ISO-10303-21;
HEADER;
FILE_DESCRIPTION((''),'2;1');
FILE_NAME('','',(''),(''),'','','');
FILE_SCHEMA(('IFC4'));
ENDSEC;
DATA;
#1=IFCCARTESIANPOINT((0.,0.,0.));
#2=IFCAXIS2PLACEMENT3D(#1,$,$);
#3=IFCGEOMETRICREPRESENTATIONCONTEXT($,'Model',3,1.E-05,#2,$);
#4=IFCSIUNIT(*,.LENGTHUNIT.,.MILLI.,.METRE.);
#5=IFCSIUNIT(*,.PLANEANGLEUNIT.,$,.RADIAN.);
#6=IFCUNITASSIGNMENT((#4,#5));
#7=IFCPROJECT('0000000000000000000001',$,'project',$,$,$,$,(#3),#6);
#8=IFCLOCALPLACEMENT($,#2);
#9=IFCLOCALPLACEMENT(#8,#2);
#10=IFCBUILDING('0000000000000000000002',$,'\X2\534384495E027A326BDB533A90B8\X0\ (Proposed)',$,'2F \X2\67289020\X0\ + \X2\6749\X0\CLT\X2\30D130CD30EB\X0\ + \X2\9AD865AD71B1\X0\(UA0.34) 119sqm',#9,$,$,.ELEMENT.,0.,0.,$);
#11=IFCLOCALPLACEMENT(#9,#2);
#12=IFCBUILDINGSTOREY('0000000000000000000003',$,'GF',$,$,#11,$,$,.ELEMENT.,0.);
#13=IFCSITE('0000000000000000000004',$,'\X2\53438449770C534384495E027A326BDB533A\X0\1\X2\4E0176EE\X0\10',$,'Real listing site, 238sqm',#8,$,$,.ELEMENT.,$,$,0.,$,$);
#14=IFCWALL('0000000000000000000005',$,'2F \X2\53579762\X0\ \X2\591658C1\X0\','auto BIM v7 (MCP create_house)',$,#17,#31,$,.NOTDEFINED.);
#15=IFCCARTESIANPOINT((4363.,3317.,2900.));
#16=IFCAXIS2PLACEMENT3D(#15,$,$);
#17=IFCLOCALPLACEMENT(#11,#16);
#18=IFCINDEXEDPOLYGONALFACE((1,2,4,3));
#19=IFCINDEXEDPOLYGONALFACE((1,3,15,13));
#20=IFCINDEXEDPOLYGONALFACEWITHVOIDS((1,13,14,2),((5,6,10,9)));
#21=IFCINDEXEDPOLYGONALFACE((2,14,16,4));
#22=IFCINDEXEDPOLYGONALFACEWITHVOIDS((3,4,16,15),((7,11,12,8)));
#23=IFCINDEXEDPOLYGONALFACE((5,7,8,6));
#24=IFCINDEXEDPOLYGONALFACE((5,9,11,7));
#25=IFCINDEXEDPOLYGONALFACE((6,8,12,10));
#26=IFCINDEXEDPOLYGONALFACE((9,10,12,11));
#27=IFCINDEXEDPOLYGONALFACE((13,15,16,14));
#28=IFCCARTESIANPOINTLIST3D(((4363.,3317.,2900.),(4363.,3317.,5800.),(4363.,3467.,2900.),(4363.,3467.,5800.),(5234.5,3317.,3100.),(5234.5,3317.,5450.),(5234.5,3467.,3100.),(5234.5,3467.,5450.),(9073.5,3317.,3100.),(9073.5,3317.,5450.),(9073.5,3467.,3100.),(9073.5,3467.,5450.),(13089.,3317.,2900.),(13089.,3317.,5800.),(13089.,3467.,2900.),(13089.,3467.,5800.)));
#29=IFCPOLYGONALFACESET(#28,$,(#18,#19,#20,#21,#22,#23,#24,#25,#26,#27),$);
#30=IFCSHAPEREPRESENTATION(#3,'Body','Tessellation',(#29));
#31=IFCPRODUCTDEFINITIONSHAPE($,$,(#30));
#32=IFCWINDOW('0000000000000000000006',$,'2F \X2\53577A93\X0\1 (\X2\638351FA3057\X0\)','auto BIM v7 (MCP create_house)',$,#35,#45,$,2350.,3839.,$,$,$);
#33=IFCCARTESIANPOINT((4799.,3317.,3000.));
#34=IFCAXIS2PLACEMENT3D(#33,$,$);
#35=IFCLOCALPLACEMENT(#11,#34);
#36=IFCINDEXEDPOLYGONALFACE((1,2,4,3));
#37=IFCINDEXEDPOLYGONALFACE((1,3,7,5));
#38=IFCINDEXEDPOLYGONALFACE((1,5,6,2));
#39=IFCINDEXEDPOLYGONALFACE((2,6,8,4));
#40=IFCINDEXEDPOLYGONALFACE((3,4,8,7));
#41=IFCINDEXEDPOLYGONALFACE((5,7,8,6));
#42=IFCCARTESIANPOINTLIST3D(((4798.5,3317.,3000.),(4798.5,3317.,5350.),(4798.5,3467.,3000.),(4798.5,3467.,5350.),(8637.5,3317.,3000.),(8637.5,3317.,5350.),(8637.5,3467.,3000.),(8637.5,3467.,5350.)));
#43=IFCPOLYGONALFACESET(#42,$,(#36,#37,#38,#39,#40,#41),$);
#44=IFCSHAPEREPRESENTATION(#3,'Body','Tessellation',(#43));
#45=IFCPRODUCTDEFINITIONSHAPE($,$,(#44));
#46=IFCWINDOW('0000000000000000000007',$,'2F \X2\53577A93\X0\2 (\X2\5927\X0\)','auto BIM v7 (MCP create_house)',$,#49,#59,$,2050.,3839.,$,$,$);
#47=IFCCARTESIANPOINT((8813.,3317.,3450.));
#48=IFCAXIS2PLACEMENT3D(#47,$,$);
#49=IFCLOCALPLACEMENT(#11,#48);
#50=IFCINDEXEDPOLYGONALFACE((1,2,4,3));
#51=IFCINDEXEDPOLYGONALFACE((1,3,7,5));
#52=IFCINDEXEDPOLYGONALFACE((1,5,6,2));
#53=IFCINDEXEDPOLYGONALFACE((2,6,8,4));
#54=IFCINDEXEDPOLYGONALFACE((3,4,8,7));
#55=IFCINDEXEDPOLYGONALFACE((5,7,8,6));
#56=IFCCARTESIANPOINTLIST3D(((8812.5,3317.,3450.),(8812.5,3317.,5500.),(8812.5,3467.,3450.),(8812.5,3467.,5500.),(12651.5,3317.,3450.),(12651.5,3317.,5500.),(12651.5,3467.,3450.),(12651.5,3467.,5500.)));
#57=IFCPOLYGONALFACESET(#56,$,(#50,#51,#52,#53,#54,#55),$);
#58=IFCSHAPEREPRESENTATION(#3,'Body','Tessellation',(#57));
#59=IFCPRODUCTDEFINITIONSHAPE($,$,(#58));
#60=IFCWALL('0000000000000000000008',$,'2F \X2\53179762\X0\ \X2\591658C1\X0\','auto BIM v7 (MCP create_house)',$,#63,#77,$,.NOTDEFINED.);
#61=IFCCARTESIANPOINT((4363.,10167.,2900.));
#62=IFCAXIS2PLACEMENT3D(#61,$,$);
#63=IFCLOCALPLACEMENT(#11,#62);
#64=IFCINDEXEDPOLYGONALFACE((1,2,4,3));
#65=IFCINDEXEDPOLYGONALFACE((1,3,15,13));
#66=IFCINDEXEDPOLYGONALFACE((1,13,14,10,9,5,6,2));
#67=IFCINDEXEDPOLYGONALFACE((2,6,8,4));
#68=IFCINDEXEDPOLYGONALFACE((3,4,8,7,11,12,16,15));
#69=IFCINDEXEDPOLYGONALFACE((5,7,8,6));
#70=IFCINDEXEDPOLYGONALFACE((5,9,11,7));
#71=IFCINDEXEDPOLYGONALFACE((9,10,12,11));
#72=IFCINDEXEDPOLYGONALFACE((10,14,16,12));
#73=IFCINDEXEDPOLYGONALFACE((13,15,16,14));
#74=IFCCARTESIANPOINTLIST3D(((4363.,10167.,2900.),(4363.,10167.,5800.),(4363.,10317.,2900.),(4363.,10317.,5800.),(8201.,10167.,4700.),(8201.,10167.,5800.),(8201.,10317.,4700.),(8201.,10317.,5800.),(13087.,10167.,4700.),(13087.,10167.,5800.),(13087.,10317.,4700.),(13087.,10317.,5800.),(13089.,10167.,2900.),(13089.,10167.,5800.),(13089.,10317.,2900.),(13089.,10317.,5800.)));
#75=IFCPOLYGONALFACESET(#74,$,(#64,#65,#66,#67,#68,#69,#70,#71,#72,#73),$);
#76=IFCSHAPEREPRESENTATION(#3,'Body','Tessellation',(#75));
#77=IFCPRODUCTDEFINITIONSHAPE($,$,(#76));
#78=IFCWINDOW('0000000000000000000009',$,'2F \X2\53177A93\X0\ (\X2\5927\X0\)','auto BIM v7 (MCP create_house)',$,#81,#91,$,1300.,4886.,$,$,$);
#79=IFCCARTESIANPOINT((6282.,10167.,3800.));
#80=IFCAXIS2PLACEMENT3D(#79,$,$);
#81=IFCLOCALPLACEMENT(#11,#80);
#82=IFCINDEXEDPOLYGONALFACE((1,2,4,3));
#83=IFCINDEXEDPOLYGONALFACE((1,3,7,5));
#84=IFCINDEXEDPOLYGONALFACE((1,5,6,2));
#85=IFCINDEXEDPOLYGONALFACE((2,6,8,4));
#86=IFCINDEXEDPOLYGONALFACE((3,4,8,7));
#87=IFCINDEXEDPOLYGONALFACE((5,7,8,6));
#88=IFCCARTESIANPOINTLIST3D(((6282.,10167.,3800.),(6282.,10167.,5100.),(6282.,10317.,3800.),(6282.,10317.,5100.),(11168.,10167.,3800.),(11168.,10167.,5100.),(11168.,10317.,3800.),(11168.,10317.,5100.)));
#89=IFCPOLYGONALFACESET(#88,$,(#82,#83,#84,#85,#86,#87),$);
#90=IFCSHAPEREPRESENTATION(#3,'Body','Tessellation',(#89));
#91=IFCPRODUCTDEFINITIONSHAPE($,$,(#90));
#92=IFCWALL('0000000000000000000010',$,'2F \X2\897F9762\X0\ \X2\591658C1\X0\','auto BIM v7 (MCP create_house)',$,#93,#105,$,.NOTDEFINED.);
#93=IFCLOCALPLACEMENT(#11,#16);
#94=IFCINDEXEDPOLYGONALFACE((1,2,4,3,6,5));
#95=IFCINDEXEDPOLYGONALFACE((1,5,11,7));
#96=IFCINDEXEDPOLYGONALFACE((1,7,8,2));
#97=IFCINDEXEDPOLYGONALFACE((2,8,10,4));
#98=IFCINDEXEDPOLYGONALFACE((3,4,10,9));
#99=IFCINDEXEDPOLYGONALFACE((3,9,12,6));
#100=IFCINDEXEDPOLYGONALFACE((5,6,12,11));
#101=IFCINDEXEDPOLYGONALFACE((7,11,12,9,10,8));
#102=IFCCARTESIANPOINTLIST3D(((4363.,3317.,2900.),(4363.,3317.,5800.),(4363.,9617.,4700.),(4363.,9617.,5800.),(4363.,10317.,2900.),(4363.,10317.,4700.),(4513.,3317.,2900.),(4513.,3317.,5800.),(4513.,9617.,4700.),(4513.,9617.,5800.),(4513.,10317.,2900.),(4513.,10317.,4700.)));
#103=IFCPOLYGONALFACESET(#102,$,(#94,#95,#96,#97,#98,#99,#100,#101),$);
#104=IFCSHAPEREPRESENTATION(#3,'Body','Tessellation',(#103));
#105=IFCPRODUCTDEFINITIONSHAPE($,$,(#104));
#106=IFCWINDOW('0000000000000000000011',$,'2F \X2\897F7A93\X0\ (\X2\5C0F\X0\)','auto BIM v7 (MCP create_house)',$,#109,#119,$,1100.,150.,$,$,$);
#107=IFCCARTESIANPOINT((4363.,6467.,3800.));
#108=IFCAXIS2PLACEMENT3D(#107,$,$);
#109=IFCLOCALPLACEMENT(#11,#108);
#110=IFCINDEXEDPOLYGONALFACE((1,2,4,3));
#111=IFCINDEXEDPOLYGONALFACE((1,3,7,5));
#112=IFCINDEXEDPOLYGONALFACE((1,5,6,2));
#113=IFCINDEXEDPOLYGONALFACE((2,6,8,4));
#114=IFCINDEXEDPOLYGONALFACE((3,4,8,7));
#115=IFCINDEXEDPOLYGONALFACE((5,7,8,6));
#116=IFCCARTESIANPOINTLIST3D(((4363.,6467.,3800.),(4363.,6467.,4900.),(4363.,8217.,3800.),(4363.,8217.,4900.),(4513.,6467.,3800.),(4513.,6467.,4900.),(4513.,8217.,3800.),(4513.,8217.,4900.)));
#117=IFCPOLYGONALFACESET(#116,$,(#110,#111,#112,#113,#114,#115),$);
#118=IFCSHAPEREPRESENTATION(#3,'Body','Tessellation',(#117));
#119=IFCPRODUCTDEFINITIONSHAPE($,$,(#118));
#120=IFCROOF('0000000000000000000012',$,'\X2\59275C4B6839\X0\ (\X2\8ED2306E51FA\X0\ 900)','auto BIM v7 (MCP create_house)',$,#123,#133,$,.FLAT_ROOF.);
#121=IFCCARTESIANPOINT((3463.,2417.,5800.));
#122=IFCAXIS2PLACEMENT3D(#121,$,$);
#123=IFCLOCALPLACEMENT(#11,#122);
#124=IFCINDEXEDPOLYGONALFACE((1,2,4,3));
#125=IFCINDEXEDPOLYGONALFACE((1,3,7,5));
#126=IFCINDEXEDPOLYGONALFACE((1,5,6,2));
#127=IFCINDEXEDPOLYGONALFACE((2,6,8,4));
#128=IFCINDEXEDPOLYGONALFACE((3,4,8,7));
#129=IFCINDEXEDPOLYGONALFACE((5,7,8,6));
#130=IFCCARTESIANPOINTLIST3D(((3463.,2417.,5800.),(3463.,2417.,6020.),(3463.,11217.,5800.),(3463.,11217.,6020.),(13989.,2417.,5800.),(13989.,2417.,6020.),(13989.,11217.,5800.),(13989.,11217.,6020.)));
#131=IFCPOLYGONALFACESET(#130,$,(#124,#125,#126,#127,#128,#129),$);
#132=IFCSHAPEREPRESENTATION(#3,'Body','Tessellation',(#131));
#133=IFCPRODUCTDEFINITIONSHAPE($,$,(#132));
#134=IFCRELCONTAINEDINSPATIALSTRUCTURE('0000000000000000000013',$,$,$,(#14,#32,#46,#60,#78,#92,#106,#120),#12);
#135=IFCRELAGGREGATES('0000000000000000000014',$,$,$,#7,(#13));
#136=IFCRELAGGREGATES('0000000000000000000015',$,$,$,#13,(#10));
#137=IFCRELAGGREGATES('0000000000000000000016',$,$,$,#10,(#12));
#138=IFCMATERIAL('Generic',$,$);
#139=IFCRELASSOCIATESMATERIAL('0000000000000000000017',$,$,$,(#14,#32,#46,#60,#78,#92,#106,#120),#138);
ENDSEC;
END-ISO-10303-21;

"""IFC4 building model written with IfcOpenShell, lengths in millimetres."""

from ifc_helpers import new_model, si_unit, frame, frame_2d, origin, place, context, project, spatial, rectangle, extrude, material, element, fill, save


model = new_model("IFC4")

# Units and contexts
model_context = context("Model", 3, precision=1e-05, world=origin())
ifc_project = project(units=[si_unit("LENGTHUNIT", "METRE", prefix="MILLI"), si_unit("PLANEANGLEUNIT", "RADIAN")], contexts=[model_context])

# Site, building, storey
site_placement = place(None, origin())
site = spatial("IfcSite", under=ifc_project, at=site_placement, Name="千葉県千葉市稲毛区1丁目10", ObjectType="Real listing site, 238sqm", CompositionType="ELEMENT", RefElevation=0.0)
building_placement = place(site_placement, origin())
building = spatial("IfcBuilding", under=site, at=building_placement, Name="千葉市稲毛区邸 (Proposed)", ObjectType="2F 木造 + 杉CLTパネル + 高断熱(UA0.34) 119sqm", CompositionType="ELEMENT", ElevationOfRefHeight=0.0, ElevationOfTerrain=0.0)
storey_placement = place(building_placement, origin())
storey = spatial("IfcBuildingStorey", under=building, at=storey_placement, Name="GF", CompositionType="ELEMENT", Elevation=0.0)

# Shared definitions
ifc_material = material(Name="Generic")

# Wall, openings, windows
wall_1_placement = place(storey_placement, frame((4363.0, 3317.0, 2900.0)))
wall_1 = element("IfcWall", 1, at=wall_1_placement, inside=storey, material=ifc_material, Name="2F 南面 外壁", Description="auto BIM v7 (MCP create_house)", PredefinedType="NOTDEFINED", context=model_context, shape_type="SweptSolid", body=[
    extrude(rectangle(XDim=8726.0, YDim=150.0, at=frame_2d((4363.0, 75.0))), frame((4363.0, 3317.0, 2900.0)), (0.0, 0.0, 1.0), 2900.0),
])
opening_1_placement = place(storey_placement, frame((4799.0, 3317.0, 3000.0)))
opening_1 = element("IfcOpeningElement", 2, at=opening_1_placement, cuts=wall_1, PredefinedType="NOTDEFINED", context=model_context, shape_type="SweptSolid", body=[
    extrude(rectangle(XDim=3839.0, YDim=150.0, at=frame_2d((1919.0, 75.0))), frame((4799.0, 3317.0, 3000.0)), (0.0, 0.0, 1.0), 2350.0),
])
opening_2_placement = place(storey_placement, frame((8813.0, 3317.0, 3450.0)))
opening_2 = element("IfcOpeningElement", 3, at=opening_2_placement, cuts=wall_1, PredefinedType="NOTDEFINED", context=model_context, shape_type="SweptSolid", body=[
    extrude(rectangle(XDim=3839.0, YDim=150.0, at=frame_2d((1919.0, 75.0))), frame((8813.0, 3317.0, 3450.0)), (0.0, 0.0, 1.0), 2050.0),
])
window_1_placement = place(storey_placement, frame((4799.0, 3317.0, 3000.0)))
window_1 = element("IfcWindow", 4, at=window_1_placement, inside=storey, material=ifc_material, Name="2F 南窓1 (掃出し)", Description="auto BIM v7 (MCP create_house)", OverallHeight=2350.0, OverallWidth=3839.0, context=model_context, shape_type="SweptSolid", body=[
    extrude(rectangle(XDim=3839.0, YDim=150.0, at=frame_2d((1919.0, 75.0))), frame((4799.0, 3317.0, 3000.0)), (0.0, 0.0, 1.0), 2350.0),
])
fill(opening_1, window_1)
window_2_placement = place(storey_placement, frame((8813.0, 3317.0, 3450.0)))
window_2 = element("IfcWindow", 5, at=window_2_placement, inside=storey, material=ifc_material, Name="2F 南窓2 (大)", Description="auto BIM v7 (MCP create_house)", OverallHeight=2050.0, OverallWidth=3839.0, context=model_context, shape_type="SweptSolid", body=[
    extrude(rectangle(XDim=3839.0, YDim=150.0, at=frame_2d((1919.0, 75.0))), frame((8813.0, 3317.0, 3450.0)), (0.0, 0.0, 1.0), 2050.0),
])
fill(opening_2, window_2)

# Walls, openings, windows
wall_2_placement = place(storey_placement, frame((4363.0, 10167.0, 2900.0)))
wall_2 = element("IfcWall", 6, at=wall_2_placement, inside=storey, material=ifc_material, Name="2F 北面 外壁", Description="auto BIM v7 (MCP create_house)", PredefinedType="NOTDEFINED", context=model_context, shape_type="SweptSolid", body=[
    extrude(rectangle(XDim=8726.0, YDim=150.0, at=frame_2d((4363.0, 75.0))), frame((4363.0, 10167.0, 2900.0)), (0.0, 0.0, 1.0), 2900.0),
])
opening_3_placement = place(storey_placement, frame((6282.0, 10167.0, 3800.0)))
opening_3 = element("IfcOpeningElement", 7, at=opening_3_placement, cuts=wall_2, PredefinedType="NOTDEFINED", context=model_context, shape_type="SweptSolid", body=[
    extrude(rectangle(XDim=4886.0, YDim=150.0, at=frame_2d((2443.0, 75.0))), frame((6282.0, 10167.0, 3800.0)), (0.0, 0.0, 1.0), 1300.0),
])
window_3_placement = place(storey_placement, frame((6282.0, 10167.0, 3800.0)))
window_3 = element("IfcWindow", 8, at=window_3_placement, inside=storey, material=ifc_material, Name="2F 北窓 (大)", Description="auto BIM v7 (MCP create_house)", OverallHeight=1300.0, OverallWidth=4886.0, context=model_context, shape_type="SweptSolid", body=[
    extrude(rectangle(XDim=4886.0, YDim=150.0, at=frame_2d((2443.0, 75.0))), frame((6282.0, 10167.0, 3800.0)), (0.0, 0.0, 1.0), 1300.0),
])
fill(opening_3, window_3)
wall_3_placement = place(storey_placement, frame((4363.0, 3317.0, 2900.0)))
wall_3 = element("IfcWall", 9, at=wall_3_placement, inside=storey, material=ifc_material, Name="2F 西面 外壁", Description="auto BIM v7 (MCP create_house)", PredefinedType="NOTDEFINED", context=model_context, shape_type="SweptSolid", body=[
    extrude(rectangle(XDim=150.0, YDim=7000.0, at=frame_2d((75.0, 3500.0))), frame((4363.0, 3317.0, 2900.0)), (0.0, 0.0, 1.0), 2900.0),
])
opening_4_placement = place(storey_placement, frame((4363.0, 6467.0, 3800.0)))
opening_4 = element("IfcOpeningElement", 10, at=opening_4_placement, cuts=wall_3, PredefinedType="NOTDEFINED", context=model_context, shape_type="SweptSolid", body=[
    extrude(rectangle(XDim=150.0, YDim=1750.0, at=frame_2d((75.0, 875.0))), frame((4363.0, 6467.0, 3800.0)), (0.0, 0.0, 1.0), 1100.0),
])
window_4_placement = place(storey_placement, frame((4363.0, 6467.0, 3800.0)))
window_4 = element("IfcWindow", 11, at=window_4_placement, inside=storey, material=ifc_material, Name="2F 西窓 (小)", Description="auto BIM v7 (MCP create_house)", OverallHeight=1100.0, OverallWidth=150.0, context=model_context, shape_type="SweptSolid", body=[
    extrude(rectangle(XDim=150.0, YDim=1750.0, at=frame_2d((75.0, 875.0))), frame((4363.0, 6467.0, 3800.0)), (0.0, 0.0, 1.0), 1100.0),
])
fill(opening_4, window_4)

# Roof
roof_placement = place(storey_placement, frame((3463.0, 2417.0, 5800.0)))
element("IfcRoof", 12, at=roof_placement, inside=storey, material=ifc_material, Name="大屋根 (軒の出 900)", Description="auto BIM v7 (MCP create_house)", PredefinedType="FLAT_ROOF", context=model_context, shape_type="SweptSolid", body=[
    extrude(rectangle(XDim=10526.0, YDim=8800.0, at=frame_2d((5263.0, 4400.0))), frame((3463.0, 2417.0, 5800.0)), (0.0, 0.0, 1.0), 220.0),
])

save(model, "model.ifc")
